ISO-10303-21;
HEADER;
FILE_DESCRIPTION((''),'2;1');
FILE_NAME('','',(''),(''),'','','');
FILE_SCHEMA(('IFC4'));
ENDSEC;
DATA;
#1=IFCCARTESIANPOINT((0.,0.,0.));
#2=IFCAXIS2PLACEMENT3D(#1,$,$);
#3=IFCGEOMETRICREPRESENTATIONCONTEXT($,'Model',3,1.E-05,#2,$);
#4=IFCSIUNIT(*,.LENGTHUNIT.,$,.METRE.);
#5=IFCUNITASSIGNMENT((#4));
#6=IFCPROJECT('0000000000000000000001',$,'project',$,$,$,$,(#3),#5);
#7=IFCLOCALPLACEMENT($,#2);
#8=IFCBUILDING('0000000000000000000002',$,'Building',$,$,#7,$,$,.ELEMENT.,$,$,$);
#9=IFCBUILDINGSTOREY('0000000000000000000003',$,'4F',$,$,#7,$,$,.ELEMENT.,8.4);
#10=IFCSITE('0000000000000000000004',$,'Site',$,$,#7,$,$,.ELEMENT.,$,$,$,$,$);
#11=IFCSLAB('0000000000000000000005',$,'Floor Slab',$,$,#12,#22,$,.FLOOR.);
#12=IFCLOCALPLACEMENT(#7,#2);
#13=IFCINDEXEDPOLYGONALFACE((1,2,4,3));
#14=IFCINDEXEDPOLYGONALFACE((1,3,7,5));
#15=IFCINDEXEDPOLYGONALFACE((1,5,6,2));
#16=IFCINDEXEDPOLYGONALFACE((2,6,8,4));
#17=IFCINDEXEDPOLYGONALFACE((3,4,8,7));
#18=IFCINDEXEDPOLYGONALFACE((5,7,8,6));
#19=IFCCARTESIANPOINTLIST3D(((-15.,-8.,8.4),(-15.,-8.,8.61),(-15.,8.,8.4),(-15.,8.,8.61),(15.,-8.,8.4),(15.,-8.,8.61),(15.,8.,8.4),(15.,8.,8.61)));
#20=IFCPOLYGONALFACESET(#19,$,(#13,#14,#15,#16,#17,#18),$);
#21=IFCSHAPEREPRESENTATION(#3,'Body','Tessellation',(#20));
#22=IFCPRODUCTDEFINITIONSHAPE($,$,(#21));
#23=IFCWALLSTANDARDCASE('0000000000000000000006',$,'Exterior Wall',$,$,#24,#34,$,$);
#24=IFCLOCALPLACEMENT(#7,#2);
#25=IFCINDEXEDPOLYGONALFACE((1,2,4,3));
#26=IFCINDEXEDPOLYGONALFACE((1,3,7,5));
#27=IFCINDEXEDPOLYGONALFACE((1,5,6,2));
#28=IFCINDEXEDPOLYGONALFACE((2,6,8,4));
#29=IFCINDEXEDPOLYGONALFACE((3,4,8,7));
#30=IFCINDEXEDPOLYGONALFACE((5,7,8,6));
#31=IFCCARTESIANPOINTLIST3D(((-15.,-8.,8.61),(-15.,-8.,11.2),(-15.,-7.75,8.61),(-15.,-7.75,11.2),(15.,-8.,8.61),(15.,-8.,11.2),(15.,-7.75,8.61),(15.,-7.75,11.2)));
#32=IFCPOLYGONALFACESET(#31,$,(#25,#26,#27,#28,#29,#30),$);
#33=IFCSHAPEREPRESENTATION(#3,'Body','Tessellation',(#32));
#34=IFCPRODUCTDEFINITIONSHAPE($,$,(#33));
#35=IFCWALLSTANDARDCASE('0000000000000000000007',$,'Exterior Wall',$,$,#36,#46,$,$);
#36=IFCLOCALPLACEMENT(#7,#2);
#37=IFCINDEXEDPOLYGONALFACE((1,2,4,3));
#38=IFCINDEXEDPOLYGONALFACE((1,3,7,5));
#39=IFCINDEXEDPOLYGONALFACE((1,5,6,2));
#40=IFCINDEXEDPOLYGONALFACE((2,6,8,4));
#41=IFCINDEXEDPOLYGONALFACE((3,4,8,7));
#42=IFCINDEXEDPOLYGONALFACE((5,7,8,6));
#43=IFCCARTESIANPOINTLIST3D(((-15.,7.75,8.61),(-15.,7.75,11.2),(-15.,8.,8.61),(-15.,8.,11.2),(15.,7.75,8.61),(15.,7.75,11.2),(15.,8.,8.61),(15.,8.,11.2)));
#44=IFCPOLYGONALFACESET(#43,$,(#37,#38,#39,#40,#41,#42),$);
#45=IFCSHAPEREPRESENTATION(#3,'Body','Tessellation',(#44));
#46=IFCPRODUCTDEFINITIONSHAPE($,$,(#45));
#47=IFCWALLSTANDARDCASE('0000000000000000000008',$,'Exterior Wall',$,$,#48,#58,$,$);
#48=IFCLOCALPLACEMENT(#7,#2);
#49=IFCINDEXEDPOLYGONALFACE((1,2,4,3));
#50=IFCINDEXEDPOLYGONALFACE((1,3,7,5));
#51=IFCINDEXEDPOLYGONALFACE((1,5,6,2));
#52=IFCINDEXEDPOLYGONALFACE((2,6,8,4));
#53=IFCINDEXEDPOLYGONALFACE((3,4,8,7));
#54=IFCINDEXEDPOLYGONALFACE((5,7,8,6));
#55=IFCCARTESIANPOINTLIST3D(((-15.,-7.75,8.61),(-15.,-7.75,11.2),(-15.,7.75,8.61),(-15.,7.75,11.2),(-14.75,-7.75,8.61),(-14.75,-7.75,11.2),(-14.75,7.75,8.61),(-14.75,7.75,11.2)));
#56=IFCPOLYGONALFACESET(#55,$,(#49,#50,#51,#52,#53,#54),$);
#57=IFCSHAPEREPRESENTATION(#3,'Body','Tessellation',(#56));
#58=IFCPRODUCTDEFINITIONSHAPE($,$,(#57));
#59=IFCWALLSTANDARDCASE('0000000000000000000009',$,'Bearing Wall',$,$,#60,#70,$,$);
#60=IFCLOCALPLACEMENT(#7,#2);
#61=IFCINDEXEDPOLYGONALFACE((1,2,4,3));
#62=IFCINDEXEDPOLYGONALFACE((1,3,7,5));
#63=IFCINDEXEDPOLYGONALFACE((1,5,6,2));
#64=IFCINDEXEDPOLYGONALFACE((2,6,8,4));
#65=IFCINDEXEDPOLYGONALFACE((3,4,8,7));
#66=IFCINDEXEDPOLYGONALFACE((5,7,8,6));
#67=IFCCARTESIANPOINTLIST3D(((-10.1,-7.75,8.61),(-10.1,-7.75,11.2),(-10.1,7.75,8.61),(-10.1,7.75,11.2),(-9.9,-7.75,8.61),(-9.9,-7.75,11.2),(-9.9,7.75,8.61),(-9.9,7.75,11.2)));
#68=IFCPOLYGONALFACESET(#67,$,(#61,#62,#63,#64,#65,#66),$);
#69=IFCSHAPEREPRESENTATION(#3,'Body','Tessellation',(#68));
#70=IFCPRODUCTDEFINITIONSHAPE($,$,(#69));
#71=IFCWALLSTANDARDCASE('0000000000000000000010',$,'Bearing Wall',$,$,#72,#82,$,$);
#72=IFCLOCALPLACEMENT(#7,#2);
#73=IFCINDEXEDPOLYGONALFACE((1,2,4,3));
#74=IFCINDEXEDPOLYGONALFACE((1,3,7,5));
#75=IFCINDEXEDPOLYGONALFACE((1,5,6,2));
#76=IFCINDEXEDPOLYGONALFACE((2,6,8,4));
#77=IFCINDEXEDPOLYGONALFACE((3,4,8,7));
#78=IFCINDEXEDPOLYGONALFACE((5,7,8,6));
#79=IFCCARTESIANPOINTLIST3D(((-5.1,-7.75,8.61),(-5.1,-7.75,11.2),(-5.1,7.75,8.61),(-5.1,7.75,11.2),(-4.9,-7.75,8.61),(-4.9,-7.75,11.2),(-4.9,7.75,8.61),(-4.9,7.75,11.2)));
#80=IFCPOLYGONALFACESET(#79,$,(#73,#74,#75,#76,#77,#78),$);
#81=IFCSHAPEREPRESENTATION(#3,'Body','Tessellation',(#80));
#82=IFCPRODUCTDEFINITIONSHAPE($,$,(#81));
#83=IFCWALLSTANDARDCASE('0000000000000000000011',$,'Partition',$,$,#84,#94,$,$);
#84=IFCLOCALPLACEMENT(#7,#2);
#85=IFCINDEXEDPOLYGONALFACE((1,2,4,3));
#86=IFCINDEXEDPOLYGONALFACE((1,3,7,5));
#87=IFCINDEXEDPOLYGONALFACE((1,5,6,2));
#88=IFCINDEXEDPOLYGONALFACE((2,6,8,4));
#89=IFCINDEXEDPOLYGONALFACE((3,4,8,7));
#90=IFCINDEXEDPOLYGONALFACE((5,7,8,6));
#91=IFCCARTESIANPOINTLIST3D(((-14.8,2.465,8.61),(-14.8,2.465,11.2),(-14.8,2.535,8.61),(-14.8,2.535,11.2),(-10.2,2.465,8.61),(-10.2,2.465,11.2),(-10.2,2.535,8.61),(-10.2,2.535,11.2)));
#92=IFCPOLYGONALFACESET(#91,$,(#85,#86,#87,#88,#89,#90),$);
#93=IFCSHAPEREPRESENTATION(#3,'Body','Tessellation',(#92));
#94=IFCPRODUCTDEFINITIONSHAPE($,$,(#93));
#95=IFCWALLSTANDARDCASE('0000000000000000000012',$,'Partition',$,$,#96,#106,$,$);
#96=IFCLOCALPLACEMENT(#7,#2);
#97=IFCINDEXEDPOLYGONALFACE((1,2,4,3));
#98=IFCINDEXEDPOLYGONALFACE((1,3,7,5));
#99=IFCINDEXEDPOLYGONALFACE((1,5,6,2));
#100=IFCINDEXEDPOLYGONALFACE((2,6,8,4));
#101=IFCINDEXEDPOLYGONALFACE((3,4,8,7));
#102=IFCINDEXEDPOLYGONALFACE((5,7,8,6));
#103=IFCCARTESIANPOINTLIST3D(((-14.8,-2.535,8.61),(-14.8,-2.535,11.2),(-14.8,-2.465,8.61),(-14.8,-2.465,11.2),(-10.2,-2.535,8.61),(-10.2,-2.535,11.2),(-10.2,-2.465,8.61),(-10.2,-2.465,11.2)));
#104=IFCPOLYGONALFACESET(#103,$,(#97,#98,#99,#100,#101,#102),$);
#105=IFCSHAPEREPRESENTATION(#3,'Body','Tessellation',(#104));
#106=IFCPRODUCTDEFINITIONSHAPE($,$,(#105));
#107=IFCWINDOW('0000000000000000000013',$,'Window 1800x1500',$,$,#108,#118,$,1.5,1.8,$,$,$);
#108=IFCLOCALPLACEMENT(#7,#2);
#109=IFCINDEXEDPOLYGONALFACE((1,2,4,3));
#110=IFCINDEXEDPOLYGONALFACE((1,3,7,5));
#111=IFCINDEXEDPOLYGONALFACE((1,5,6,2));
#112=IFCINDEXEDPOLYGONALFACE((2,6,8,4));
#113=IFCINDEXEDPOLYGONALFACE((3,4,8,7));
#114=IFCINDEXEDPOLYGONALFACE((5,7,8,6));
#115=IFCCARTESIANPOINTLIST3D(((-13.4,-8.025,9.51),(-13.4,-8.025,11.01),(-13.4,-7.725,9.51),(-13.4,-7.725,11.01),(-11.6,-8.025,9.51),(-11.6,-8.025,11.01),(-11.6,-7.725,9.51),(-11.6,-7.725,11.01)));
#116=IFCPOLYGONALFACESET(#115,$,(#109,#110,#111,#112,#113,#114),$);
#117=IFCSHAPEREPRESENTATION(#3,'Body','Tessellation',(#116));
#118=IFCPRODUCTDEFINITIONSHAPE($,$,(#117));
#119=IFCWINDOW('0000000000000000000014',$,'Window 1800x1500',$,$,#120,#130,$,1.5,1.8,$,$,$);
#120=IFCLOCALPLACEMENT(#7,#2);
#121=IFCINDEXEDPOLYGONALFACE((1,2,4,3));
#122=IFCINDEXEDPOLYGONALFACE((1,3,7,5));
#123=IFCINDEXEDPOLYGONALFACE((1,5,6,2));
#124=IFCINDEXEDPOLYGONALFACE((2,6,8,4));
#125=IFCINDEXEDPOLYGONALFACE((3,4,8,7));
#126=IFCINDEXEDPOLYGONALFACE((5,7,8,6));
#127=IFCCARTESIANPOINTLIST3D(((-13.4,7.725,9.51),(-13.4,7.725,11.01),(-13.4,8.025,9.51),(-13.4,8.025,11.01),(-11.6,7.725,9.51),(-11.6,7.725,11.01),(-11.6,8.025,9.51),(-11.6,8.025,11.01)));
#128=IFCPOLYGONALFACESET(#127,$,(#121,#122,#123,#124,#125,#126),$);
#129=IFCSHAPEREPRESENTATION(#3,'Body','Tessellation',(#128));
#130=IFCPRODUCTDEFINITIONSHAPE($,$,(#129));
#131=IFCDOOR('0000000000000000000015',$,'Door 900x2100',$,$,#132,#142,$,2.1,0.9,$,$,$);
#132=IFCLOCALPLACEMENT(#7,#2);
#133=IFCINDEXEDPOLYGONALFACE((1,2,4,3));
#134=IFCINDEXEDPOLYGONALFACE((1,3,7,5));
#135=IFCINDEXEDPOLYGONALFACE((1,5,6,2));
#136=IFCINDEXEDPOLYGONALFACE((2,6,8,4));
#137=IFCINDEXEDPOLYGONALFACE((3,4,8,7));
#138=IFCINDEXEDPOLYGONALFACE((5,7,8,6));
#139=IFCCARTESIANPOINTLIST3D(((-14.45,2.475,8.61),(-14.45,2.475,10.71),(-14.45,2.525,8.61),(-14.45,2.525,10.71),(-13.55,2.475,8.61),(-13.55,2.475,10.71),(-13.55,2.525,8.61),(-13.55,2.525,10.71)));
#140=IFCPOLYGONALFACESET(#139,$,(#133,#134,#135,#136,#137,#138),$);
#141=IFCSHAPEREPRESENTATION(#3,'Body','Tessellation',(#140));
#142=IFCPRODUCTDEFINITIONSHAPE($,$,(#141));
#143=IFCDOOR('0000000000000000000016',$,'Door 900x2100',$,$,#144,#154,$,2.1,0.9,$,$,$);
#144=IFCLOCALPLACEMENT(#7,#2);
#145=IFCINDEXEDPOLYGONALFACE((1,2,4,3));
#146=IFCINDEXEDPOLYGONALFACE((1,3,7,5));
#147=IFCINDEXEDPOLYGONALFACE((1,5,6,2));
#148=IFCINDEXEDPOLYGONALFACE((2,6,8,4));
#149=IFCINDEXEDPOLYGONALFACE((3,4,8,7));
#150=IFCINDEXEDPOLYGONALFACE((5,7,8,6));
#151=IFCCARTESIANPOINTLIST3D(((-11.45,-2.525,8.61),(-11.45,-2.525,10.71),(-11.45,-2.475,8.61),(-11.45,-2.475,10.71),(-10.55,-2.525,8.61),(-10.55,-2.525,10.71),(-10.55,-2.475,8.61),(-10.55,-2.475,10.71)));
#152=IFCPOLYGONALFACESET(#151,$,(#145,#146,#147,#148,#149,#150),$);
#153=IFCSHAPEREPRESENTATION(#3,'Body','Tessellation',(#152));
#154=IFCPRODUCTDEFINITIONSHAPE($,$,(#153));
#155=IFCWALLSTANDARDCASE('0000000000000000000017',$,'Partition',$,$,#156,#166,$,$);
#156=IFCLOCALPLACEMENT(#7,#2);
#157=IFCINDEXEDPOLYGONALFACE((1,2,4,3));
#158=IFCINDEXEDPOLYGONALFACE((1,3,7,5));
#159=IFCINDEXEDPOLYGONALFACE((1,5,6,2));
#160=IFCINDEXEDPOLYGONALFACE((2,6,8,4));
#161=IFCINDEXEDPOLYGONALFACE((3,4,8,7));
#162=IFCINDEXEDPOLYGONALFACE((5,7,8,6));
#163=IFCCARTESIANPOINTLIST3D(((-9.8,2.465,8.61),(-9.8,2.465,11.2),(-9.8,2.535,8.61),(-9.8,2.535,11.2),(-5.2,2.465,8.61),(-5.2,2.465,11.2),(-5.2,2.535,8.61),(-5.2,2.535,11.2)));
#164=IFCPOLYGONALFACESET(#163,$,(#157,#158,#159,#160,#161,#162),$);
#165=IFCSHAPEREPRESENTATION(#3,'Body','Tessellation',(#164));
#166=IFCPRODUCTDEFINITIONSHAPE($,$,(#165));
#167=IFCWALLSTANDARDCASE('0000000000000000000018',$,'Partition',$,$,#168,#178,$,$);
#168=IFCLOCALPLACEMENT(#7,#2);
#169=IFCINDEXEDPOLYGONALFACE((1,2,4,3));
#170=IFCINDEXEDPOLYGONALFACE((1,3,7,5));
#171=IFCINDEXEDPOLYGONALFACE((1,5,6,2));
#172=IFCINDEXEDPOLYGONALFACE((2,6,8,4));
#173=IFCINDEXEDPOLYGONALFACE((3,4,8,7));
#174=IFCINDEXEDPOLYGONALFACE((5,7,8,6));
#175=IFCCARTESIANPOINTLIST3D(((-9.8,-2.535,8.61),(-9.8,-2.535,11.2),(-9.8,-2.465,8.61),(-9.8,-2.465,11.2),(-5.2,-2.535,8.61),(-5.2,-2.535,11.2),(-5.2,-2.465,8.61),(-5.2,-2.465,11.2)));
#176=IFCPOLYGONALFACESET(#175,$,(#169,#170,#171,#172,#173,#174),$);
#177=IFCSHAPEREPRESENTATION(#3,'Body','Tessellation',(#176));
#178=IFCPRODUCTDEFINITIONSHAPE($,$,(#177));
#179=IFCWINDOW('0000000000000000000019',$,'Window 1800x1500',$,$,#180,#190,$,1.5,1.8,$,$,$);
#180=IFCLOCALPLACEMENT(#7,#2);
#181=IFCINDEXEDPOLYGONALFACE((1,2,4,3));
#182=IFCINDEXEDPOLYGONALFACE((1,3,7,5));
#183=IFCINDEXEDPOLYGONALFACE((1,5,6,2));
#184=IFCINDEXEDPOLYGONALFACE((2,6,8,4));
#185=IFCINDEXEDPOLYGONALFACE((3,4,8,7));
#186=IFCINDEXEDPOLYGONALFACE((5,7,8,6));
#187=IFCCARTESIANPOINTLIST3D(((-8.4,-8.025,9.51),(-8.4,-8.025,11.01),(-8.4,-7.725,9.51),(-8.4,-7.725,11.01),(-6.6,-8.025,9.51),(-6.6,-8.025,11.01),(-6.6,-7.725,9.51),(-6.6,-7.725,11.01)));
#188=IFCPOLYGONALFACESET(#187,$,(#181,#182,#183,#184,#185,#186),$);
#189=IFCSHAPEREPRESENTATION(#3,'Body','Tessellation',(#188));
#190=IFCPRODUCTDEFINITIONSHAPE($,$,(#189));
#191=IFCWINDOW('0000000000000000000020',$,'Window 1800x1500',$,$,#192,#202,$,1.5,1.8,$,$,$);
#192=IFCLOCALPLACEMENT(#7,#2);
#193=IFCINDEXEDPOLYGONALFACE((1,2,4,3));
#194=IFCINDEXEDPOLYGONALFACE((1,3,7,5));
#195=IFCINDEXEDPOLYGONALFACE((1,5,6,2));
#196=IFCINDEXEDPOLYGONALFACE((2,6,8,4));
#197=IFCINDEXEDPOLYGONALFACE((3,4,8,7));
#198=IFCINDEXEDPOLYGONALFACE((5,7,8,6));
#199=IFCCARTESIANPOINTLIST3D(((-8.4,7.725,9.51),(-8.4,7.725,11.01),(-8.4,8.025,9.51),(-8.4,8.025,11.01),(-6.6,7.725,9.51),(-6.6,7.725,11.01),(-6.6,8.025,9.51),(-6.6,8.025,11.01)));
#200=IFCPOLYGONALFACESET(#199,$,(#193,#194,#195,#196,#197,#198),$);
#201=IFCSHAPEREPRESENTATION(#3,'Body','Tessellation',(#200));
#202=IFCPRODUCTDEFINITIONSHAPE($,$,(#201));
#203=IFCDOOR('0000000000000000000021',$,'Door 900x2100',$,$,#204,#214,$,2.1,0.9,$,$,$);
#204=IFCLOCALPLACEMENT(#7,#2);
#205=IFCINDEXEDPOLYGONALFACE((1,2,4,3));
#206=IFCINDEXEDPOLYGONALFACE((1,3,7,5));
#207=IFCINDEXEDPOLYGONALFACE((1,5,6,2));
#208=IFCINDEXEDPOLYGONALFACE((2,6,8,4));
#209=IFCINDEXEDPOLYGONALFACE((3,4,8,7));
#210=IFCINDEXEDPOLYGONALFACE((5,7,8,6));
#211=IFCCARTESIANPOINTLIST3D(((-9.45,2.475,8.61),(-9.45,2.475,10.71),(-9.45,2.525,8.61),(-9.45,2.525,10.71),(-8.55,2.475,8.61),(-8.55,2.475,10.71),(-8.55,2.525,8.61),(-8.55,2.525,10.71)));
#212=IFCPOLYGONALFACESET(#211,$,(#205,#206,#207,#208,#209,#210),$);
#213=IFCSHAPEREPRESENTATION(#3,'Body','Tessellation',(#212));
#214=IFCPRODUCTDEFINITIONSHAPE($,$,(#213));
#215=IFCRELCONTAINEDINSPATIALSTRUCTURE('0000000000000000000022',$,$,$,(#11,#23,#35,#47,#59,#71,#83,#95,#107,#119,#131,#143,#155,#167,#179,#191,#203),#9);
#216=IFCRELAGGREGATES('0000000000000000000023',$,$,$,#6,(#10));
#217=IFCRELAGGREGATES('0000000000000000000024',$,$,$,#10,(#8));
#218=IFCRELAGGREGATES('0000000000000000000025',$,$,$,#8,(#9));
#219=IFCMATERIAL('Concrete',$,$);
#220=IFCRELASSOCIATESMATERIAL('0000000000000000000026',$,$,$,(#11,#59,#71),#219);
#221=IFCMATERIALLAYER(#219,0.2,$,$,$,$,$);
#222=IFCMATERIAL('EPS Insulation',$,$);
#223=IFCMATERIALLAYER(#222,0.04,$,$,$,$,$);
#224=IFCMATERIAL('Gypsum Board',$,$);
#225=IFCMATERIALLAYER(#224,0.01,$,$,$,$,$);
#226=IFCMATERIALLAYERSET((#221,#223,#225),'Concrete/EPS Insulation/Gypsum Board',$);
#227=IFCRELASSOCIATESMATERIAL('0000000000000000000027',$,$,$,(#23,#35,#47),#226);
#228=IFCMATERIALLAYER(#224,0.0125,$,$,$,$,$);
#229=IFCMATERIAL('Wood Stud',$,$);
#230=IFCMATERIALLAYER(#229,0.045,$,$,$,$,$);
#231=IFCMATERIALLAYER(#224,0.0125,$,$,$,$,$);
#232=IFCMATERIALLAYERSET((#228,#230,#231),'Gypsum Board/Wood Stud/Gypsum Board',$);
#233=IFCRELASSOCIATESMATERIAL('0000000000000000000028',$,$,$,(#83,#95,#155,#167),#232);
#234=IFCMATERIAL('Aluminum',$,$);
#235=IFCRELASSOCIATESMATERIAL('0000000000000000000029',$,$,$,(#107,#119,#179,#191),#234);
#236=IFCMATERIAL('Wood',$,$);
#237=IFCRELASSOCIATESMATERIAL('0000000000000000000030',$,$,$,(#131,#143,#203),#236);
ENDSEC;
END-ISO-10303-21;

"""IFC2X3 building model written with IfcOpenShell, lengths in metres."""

from ifc_helpers import new_model, si_unit, frame, origin, origin_2d, place, context, project, spatial, rectangle, extrude, material, layer, layer_set, layer_usage, element, save


model = new_model("IFC2X3")

# Units and contexts
model_context = context("Model", 3, precision=1e-05, world=origin())
ifc_project = project(units=[si_unit("LENGTHUNIT", "METRE")], contexts=[model_context])

# Site, building, storey
placement = place(None, origin())
site = spatial("IfcSite", under=ifc_project, at=placement, Name="Site", CompositionType="ELEMENT")
building = spatial("IfcBuilding", under=site, at=placement, Name="Building", CompositionType="ELEMENT")
storey = spatial("IfcBuildingStorey", under=building, at=placement, Name="4F", CompositionType="ELEMENT", Elevation=8.4)

# Slab
ifc_material_1 = material(Name="Concrete")
slab_placement = place(None, frame((0.0, 0.0, 8.4)))
element("IfcSlab", 1, at=slab_placement, inside=storey, material=ifc_material_1, Name="Floor Slab", PredefinedType="FLOOR", context=model_context, shape_type="SweptSolid", body=[
    extrude(rectangle(XDim=30.0, YDim=16.0, at=origin_2d()), origin(), (0.0, 0.0, 1.0), 0.21),
])

# Walls
ifc_layer_1 = layer(ifc_material_1, 0.2)
ifc_material_2 = material(Name="EPS Insulation")
ifc_layer_2 = layer(ifc_material_2, 0.04)
ifc_material_3 = material(Name="Gypsum Board")
ifc_layer_3 = layer(ifc_material_3, 0.01)
ifc_layer_set_1 = layer_set([ifc_layer_1, ifc_layer_2, ifc_layer_3], Name="Concrete/EPS Insulation/Gypsum Board")
ifc_layer_usage_1 = layer_usage(ifc_layer_set_1, "AXIS2", "POSITIVE", 0.0)
for number, where, name in (
    (2, (0.0, -7.875, 8.61), "Exterior Wall"),
    (3, (0.0, 7.875, 8.61), "Exterior Wall"),
):
    element("IfcWallStandardCase", number, at=place(None, frame(where)), inside=storey, material=ifc_layer_usage_1, Name=name, context=model_context, shape_type="SweptSolid", body=[
        extrude(rectangle(XDim=30.0, YDim=0.25, at=origin_2d()), origin(), (0.0, 0.0, 1.0), 2.59),
    ])
wall_placement = place(None, frame((-14.875, 0.0, 8.61)))
element("IfcWallStandardCase", 4, at=wall_placement, inside=storey, material=ifc_layer_usage_1, Name="Exterior Wall", context=model_context, shape_type="SweptSolid", body=[
    extrude(rectangle(XDim=0.25, YDim=15.5, at=origin_2d()), origin(), (0.0, 0.0, 1.0), 2.59),
])
for number, where, name in (
    (5, (-10.0, 0.0, 8.61), "Bearing Wall"),
    (6, (-5.0, 0.0, 8.61), "Bearing Wall"),
):
    element("IfcWallStandardCase", number, at=place(None, frame(where)), inside=storey, material=ifc_material_1, Name=name, context=model_context, shape_type="SweptSolid", body=[
        extrude(rectangle(XDim=0.2, YDim=15.5, at=origin_2d()), origin(), (0.0, 0.0, 1.0), 2.59),
    ])
ifc_layer_4 = layer(ifc_material_3, 0.0125)
ifc_material_4 = material(Name="Wood Stud")
ifc_layer_5 = layer(ifc_material_4, 0.045)
ifc_layer_6 = layer(ifc_material_3, 0.0125)
ifc_layer_set_2 = layer_set([ifc_layer_4, ifc_layer_5, ifc_layer_6], Name="Gypsum Board/Wood Stud/Gypsum Board")
ifc_layer_usage_2 = layer_usage(ifc_layer_set_2, "AXIS2", "POSITIVE", 0.0)
for number, where, name in (
    (7, (-12.5, 2.5, 8.61), "Partition"),
    (8, (-12.5, -2.5, 8.61), "Partition"),
):
    element("IfcWallStandardCase", number, at=place(None, frame(where)), inside=storey, material=ifc_layer_usage_2, Name=name, context=model_context, shape_type="SweptSolid", body=[
        extrude(rectangle(XDim=4.6, YDim=0.07, at=origin_2d()), origin(), (0.0, 0.0, 1.0), 2.59),
    ])

# Windows
ifc_material_5 = material(Name="Aluminum")
for number, where, name in (
    (9, (-12.5, -7.875, 9.51), "Window 1800x1500"),
    (10, (-12.5, 7.875, 9.51), "Window 1800x1500"),
):
    element("IfcWindow", number, at=place(None, frame(where)), inside=storey, material=ifc_material_5, Name=name, OverallHeight=1.5, OverallWidth=1.8, context=model_context, shape_type="SweptSolid", body=[
        extrude(rectangle(XDim=1.8, YDim=0.3, at=origin_2d()), origin(), (0.0, 0.0, 1.0), 1.5),
    ])

# Doors
ifc_material_6 = material(Name="Wood")
for number, where, name in (
    (11, (-14.0, 2.5, 8.61), "Door 900x2100"),
    (12, (-11.0, -2.5, 8.61), "Door 900x2100"),
):
    element("IfcDoor", number, at=place(None, frame(where)), inside=storey, material=ifc_material_6, Name=name, OverallHeight=2.1, OverallWidth=0.9, context=model_context, shape_type="SweptSolid", body=[
        extrude(rectangle(XDim=0.9, YDim=0.05, at=origin_2d()), origin(), (0.0, 0.0, 1.0), 2.1),
    ])

# Walls
for number, where, name in (
    (13, (-7.5, 2.5, 8.61), "Partition"),
    (14, (-7.5, -2.5, 8.61), "Partition"),
):
    element("IfcWallStandardCase", number, at=place(None, frame(where)), inside=storey, material=ifc_layer_usage_2, Name=name, context=model_context, shape_type="SweptSolid", body=[
        extrude(rectangle(XDim=4.6, YDim=0.07, at=origin_2d()), origin(), (0.0, 0.0, 1.0), 2.59),
    ])

# Windows
for number, where, name in (
    (15, (-7.5, -7.875, 9.51), "Window 1800x1500"),
    (16, (-7.5, 7.875, 9.51), "Window 1800x1500"),
):
    element("IfcWindow", number, at=place(None, frame(where)), inside=storey, material=ifc_material_5, Name=name, OverallHeight=1.5, OverallWidth=1.8, context=model_context, shape_type="SweptSolid", body=[
        extrude(rectangle(XDim=1.8, YDim=0.3, at=origin_2d()), origin(), (0.0, 0.0, 1.0), 1.5),
    ])

# Door
for number, where, name in (
    (17, (-9.0, 2.5, 8.61), "Door 900x2100"),
):
    element("IfcDoor", number, at=place(None, frame(where)), inside=storey, material=ifc_material_6, Name=name, OverallHeight=2.1, OverallWidth=0.9, context=model_context, shape_type="SweptSolid", body=[
        extrude(rectangle(XDim=0.9, YDim=0.05, at=origin_2d()), origin(), (0.0, 0.0, 1.0), 2.1),
    ])

save(model, "model.ifc")
